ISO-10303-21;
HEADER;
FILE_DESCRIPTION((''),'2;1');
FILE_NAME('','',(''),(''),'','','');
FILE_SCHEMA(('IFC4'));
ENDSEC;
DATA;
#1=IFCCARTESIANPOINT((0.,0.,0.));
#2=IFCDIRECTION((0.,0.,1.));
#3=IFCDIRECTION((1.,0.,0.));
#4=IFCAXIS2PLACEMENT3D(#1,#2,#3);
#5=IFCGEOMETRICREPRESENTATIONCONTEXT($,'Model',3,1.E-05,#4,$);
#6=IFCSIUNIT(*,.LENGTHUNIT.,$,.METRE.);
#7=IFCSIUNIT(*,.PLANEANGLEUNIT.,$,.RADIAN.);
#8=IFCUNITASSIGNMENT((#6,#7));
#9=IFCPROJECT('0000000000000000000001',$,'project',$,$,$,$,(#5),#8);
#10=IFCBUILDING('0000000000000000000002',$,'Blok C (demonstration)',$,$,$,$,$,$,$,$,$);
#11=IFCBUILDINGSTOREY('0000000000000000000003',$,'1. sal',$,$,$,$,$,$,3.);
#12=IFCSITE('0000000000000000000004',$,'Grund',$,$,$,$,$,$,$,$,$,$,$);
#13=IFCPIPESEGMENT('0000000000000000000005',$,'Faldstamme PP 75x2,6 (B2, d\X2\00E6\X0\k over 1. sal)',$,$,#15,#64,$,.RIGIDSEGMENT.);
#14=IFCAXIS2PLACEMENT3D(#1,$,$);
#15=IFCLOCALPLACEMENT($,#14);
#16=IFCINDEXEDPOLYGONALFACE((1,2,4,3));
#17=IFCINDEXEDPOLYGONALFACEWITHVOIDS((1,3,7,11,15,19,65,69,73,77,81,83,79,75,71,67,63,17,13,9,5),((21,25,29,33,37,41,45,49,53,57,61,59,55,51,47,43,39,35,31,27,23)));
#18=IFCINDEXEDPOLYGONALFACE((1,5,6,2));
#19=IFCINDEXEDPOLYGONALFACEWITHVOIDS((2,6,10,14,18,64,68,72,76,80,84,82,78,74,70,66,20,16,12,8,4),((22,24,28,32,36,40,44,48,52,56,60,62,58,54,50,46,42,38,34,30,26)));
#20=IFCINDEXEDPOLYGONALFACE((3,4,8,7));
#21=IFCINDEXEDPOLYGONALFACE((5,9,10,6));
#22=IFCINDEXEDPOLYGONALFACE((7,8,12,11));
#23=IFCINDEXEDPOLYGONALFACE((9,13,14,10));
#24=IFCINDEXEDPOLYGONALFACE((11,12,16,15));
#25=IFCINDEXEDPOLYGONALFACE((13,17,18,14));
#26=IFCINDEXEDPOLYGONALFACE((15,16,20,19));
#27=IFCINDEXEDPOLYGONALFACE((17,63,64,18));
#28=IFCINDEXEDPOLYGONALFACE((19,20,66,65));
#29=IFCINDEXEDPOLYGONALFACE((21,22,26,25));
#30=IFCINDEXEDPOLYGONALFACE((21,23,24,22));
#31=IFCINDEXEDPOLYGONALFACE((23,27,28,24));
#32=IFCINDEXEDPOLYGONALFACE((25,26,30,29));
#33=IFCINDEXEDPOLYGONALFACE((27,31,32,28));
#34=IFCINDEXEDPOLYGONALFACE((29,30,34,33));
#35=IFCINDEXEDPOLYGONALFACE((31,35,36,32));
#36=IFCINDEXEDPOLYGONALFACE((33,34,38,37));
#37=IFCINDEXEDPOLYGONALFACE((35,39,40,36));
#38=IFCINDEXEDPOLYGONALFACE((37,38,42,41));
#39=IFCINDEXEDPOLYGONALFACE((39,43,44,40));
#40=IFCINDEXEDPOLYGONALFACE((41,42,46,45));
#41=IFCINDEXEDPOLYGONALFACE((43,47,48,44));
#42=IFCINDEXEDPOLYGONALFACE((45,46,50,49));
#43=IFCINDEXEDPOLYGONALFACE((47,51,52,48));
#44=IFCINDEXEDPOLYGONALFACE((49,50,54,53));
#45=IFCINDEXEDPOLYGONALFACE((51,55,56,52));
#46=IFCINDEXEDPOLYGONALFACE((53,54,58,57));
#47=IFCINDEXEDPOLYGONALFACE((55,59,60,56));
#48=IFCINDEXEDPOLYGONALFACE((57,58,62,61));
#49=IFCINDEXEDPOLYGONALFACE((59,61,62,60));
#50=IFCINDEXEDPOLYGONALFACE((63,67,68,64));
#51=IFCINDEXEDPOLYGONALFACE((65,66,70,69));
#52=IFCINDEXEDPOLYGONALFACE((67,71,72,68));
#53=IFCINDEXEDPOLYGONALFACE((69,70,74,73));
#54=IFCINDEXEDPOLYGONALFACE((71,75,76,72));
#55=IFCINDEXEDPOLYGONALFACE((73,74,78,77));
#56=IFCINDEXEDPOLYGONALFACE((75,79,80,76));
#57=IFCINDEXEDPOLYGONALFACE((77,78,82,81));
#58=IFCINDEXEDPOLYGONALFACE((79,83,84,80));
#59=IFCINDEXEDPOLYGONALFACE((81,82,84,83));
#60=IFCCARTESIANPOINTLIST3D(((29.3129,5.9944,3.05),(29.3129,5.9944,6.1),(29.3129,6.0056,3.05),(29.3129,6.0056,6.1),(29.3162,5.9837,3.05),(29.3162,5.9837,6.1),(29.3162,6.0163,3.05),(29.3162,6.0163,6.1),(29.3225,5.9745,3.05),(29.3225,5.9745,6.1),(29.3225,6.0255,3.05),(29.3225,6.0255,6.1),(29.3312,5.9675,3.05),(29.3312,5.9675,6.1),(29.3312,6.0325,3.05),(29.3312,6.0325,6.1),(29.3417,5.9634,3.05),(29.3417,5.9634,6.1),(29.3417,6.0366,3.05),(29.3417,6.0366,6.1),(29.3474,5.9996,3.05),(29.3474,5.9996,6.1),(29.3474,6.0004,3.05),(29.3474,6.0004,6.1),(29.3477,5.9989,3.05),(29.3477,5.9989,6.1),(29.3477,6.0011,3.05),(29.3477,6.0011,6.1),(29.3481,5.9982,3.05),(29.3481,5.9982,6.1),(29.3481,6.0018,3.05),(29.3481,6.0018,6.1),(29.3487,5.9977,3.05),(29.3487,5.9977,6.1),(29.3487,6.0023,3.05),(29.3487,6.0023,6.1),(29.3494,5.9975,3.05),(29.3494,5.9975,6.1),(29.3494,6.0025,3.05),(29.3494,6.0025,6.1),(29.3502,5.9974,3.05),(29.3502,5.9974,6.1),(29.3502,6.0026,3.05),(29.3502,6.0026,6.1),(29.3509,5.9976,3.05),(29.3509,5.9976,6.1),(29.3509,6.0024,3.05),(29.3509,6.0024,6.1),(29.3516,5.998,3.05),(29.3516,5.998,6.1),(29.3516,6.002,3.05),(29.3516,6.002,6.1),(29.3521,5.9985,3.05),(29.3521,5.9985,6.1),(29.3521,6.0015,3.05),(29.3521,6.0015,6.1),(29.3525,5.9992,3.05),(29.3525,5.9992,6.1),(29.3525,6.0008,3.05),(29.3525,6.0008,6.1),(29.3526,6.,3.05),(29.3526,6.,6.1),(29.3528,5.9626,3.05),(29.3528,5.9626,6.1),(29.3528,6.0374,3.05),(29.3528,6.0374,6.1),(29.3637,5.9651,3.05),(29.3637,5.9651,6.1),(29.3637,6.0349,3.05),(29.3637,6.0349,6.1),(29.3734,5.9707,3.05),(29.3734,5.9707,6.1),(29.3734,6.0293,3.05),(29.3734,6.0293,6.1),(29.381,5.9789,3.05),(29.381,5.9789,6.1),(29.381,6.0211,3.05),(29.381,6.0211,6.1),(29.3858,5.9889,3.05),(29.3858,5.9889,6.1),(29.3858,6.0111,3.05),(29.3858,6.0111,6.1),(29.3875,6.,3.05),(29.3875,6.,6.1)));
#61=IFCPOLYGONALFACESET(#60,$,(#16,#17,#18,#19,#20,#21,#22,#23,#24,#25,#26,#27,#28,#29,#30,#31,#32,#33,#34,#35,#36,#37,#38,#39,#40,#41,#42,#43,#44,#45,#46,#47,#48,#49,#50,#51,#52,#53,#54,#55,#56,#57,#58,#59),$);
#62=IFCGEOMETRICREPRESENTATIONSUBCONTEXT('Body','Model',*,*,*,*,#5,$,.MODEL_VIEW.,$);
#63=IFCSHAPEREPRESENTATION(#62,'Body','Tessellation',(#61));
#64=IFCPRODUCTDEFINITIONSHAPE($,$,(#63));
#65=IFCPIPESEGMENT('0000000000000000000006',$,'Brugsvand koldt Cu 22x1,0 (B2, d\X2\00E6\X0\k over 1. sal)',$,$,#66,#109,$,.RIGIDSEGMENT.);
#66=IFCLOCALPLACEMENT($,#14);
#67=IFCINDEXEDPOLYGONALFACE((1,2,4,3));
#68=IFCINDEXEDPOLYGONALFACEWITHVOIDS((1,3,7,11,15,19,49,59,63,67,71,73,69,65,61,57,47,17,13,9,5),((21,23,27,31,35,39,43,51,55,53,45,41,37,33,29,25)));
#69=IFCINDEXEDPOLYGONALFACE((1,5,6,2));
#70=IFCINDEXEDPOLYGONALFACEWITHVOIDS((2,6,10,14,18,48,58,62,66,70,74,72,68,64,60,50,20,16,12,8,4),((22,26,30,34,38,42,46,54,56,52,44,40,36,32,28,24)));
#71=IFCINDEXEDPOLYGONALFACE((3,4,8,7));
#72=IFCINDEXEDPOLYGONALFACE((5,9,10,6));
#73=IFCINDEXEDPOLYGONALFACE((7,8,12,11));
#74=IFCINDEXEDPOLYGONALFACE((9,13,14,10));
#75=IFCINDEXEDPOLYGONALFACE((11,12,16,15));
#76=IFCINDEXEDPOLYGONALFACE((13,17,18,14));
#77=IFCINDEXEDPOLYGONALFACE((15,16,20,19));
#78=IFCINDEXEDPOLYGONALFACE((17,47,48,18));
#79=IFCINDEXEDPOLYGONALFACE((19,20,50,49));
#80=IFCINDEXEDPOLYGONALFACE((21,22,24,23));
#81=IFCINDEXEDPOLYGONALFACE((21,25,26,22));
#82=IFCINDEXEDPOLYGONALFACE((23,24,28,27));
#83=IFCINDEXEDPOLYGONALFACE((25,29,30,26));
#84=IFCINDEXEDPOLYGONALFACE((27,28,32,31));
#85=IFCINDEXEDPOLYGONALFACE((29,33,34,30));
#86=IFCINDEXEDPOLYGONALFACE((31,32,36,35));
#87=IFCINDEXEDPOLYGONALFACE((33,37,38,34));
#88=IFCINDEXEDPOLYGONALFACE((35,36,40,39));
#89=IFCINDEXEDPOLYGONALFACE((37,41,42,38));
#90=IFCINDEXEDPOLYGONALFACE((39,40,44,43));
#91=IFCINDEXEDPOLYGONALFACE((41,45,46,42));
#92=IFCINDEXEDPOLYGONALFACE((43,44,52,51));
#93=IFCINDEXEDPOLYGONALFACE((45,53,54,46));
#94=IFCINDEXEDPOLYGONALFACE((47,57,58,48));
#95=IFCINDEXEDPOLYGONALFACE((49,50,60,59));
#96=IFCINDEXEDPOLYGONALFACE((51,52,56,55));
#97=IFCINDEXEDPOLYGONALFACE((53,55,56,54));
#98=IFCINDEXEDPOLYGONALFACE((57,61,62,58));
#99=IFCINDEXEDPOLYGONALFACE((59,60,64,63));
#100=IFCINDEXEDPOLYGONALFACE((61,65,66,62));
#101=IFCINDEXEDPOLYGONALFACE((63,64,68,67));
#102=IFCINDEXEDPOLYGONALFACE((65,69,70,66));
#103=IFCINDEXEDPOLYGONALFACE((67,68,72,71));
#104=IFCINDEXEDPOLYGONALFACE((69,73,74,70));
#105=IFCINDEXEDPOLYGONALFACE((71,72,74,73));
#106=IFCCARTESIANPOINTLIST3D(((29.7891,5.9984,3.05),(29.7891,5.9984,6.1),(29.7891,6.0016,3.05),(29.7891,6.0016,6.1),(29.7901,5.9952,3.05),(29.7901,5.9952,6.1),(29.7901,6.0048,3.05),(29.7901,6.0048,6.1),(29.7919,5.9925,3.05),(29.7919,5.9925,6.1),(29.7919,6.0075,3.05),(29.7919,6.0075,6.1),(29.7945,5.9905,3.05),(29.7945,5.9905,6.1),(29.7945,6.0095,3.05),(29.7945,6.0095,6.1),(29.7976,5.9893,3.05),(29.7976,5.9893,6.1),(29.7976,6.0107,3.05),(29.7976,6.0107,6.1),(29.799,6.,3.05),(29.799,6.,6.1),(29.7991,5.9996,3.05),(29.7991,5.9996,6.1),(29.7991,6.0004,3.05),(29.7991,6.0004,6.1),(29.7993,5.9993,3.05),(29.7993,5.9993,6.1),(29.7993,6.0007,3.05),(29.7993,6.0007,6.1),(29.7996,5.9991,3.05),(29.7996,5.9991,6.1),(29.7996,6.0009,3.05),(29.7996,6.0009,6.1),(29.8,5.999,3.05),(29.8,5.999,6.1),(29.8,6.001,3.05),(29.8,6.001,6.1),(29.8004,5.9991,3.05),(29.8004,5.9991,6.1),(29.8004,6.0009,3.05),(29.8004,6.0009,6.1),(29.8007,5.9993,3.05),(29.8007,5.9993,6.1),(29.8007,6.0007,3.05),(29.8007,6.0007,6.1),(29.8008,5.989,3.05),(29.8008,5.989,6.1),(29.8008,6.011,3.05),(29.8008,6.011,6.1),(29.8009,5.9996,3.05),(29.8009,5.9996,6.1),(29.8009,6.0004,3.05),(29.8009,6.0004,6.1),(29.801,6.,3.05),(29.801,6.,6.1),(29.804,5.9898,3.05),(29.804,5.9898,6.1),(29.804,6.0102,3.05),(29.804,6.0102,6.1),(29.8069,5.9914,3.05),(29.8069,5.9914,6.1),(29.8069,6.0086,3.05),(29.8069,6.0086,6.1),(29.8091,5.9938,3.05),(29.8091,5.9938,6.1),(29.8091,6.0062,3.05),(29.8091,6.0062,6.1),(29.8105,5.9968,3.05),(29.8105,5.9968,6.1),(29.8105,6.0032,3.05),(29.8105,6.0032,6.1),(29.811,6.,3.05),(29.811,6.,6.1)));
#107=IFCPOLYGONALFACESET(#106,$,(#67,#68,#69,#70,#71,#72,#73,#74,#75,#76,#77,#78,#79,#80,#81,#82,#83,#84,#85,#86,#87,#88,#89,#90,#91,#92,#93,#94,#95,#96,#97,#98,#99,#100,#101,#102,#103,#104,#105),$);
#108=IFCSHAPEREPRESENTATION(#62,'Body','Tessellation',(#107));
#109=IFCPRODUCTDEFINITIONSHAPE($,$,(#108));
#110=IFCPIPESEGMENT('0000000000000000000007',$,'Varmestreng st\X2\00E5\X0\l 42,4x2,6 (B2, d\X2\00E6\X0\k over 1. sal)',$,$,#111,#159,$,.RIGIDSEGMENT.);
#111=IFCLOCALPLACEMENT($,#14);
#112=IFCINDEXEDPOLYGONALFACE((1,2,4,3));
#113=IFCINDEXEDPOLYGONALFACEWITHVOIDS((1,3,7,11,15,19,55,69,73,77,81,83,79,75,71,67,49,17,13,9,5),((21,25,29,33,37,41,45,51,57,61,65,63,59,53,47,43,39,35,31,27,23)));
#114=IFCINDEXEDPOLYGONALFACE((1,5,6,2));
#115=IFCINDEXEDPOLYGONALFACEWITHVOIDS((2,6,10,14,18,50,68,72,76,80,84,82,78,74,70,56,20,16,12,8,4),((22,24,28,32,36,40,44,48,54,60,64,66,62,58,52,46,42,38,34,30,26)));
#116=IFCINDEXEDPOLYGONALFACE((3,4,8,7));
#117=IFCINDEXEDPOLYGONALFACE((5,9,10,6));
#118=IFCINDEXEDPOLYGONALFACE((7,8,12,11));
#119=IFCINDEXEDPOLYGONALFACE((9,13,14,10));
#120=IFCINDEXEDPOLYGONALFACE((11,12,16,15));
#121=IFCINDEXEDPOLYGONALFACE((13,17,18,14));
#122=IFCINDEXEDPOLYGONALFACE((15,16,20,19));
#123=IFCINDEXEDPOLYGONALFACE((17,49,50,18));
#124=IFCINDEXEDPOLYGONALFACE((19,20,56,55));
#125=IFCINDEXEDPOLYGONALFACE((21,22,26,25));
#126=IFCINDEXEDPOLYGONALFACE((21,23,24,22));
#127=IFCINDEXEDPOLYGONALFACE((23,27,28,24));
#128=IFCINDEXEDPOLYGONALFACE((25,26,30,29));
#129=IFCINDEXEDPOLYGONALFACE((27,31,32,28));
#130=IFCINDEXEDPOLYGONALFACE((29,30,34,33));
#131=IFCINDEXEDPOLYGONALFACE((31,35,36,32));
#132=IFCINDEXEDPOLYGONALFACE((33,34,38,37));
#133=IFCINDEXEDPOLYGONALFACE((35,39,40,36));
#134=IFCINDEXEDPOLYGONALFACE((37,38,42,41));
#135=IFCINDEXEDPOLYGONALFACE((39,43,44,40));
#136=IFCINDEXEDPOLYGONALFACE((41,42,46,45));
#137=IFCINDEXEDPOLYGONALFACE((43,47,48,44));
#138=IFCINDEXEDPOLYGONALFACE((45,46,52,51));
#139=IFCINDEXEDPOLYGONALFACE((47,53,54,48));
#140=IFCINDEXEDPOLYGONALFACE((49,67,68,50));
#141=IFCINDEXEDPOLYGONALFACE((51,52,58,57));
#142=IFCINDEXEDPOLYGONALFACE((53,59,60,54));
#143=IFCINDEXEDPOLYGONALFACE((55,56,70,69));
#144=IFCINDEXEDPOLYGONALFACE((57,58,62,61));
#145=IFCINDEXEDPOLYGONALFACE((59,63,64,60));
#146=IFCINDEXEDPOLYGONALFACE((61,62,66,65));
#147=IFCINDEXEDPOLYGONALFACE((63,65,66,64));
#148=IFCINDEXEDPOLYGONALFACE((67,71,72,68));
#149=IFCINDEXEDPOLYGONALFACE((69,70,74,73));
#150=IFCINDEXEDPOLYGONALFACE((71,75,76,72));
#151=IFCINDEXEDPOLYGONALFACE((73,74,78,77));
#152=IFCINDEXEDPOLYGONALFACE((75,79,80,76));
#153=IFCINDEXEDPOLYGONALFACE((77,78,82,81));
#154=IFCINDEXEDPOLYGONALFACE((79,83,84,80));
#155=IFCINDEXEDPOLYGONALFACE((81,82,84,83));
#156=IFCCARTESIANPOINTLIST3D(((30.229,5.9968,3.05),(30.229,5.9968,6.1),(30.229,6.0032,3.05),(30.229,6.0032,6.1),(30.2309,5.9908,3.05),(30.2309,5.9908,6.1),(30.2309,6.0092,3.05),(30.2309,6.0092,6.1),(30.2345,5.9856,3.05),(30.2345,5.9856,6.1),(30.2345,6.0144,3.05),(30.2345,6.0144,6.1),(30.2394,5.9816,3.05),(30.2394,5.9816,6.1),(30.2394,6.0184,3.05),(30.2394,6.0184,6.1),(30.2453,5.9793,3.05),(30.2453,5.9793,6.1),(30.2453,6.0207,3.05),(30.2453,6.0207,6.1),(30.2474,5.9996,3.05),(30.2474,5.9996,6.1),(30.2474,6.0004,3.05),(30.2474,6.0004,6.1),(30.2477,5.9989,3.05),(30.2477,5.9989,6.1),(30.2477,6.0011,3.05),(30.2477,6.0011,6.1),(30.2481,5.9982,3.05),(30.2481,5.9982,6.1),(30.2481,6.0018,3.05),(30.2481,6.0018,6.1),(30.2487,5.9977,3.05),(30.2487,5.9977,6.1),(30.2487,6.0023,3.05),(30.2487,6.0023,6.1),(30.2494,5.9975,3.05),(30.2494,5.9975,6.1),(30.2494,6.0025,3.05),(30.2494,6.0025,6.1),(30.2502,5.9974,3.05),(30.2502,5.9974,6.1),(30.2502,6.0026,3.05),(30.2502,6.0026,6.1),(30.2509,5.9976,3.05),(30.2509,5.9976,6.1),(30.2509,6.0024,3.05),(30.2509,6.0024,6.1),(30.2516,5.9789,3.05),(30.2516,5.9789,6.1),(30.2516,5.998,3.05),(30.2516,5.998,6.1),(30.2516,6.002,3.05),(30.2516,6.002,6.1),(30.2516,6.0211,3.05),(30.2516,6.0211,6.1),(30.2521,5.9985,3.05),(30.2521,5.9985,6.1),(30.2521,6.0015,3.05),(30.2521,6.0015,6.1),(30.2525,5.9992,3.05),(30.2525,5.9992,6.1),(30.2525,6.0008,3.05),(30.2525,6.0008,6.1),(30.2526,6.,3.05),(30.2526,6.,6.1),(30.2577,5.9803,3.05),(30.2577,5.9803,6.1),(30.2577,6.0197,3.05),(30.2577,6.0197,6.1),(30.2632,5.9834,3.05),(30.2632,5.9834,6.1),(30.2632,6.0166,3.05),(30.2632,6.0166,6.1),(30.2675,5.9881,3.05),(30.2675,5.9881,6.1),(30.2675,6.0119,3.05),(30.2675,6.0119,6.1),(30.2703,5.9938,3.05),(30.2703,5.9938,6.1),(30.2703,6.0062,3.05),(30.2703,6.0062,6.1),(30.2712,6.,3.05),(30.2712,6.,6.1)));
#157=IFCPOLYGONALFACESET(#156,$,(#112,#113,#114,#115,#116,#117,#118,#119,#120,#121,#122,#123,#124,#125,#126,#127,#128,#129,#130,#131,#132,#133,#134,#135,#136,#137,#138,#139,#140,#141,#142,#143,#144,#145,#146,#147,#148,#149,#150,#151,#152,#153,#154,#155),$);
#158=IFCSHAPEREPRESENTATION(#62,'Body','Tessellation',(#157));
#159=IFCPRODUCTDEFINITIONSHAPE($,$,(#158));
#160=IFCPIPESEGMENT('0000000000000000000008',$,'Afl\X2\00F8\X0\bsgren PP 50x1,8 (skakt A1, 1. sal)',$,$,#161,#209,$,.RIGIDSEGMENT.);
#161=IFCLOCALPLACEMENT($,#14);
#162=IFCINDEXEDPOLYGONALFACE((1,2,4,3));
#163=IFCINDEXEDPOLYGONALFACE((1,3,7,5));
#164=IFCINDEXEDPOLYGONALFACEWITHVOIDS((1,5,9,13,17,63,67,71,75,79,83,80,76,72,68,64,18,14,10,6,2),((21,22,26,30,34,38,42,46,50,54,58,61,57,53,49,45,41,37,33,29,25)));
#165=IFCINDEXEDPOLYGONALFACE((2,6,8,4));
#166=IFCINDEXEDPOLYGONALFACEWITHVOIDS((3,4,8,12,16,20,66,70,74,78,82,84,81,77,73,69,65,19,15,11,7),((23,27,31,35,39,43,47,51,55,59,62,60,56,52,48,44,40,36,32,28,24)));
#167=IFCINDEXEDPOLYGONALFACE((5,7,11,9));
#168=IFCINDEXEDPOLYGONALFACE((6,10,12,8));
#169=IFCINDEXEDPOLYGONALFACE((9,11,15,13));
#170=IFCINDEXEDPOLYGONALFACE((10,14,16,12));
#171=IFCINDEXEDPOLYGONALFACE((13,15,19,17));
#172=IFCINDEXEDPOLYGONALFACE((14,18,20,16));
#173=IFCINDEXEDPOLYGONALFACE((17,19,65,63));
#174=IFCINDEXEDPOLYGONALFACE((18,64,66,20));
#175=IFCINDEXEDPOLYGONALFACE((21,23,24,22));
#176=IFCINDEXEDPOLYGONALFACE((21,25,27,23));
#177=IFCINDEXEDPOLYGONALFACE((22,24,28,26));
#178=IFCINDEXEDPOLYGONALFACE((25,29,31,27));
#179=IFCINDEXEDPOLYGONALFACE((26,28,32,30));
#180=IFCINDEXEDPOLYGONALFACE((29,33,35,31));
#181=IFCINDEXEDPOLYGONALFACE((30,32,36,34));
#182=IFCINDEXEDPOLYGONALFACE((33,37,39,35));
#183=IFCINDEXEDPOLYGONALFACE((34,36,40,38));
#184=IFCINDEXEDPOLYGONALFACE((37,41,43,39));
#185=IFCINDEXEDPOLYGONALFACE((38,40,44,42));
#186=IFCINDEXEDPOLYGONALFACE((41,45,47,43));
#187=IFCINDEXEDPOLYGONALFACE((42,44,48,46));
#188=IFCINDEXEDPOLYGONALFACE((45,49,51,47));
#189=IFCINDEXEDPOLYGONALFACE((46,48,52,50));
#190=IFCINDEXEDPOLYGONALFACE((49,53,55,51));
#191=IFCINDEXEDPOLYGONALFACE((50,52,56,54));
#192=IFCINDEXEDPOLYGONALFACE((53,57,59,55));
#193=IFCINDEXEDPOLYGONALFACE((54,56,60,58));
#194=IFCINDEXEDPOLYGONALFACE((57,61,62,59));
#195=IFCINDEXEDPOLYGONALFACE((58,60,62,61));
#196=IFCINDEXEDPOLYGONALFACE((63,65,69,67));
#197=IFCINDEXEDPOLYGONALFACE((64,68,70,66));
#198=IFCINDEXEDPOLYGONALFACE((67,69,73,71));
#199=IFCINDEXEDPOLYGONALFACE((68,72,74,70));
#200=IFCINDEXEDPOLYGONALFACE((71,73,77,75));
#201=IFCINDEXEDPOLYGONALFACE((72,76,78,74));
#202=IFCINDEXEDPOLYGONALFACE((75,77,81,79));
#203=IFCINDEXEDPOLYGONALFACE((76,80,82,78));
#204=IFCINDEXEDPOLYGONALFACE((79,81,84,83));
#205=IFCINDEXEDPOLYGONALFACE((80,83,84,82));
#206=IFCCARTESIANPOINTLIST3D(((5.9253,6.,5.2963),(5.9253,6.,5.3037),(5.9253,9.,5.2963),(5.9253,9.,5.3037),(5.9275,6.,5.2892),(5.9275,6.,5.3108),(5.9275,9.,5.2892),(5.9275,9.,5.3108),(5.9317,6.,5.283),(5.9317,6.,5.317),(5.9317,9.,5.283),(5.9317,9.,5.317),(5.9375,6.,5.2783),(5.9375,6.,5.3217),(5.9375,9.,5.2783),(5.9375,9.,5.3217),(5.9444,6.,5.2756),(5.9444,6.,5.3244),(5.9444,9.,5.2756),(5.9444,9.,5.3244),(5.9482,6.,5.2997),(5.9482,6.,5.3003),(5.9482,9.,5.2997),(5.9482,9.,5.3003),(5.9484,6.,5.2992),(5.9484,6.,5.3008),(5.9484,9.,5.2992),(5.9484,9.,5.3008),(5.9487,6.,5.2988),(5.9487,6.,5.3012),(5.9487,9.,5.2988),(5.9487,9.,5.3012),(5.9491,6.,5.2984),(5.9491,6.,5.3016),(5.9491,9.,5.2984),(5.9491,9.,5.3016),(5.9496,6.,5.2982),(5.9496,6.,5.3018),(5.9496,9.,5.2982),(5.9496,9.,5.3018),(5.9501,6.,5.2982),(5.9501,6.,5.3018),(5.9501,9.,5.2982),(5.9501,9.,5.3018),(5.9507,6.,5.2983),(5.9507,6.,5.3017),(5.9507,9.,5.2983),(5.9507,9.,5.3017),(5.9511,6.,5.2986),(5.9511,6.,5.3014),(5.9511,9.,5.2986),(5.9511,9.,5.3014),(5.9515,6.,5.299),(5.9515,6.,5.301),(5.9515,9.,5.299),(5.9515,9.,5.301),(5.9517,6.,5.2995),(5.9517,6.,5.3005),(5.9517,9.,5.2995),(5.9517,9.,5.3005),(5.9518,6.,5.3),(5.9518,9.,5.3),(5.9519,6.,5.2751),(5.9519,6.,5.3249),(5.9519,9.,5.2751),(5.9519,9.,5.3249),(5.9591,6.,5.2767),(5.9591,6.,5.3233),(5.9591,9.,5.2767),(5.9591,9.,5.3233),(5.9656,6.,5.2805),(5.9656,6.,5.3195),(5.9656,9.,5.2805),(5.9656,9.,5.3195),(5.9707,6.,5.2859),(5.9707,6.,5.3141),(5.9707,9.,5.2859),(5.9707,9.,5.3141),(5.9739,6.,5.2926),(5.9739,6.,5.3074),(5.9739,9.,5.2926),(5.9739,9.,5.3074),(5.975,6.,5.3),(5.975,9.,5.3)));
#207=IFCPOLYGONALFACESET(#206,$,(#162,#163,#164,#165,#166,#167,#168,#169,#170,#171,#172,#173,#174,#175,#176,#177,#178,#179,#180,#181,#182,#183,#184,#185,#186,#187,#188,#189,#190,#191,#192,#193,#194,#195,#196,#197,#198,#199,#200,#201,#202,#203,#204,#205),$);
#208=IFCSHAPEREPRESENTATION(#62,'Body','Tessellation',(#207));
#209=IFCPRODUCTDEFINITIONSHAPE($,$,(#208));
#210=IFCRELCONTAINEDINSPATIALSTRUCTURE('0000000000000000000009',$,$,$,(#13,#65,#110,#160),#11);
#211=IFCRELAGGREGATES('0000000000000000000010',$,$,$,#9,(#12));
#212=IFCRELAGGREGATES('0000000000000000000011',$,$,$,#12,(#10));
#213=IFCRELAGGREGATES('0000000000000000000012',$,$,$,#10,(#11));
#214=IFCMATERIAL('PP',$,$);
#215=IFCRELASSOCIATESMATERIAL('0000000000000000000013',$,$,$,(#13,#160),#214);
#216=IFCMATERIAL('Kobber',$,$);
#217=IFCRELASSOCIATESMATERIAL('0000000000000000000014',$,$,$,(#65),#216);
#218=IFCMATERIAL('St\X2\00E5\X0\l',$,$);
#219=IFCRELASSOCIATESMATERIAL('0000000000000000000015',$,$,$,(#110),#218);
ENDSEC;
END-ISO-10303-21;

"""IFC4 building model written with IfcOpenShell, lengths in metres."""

from ifc_helpers import new_model, si_unit, frame, origin_with_axes, place, context, subcontext, project, spatial, hollow_circle, extrude, material, element, save


model = new_model("IFC4")

# Units and contexts
model_context = context("Model", 3, precision=1e-05, world=origin_with_axes())
body_context = subcontext(model_context, "Body", "Model", "MODEL_VIEW")
ifc_project = project(units=[si_unit("LENGTHUNIT", "METRE"), si_unit("PLANEANGLEUNIT", "RADIAN")], contexts=[model_context])

# Site, building, storey
site = spatial("IfcSite", under=ifc_project, Name="Grund")
building = spatial("IfcBuilding", under=site, Name="Blok C (demonstration)")
storey = spatial("IfcBuildingStorey", under=building, Name="1. sal", Elevation=3.0)

# Pipe segments
ifc_material_1 = material(Name="Kobber")
ifc_material_2 = material(Name="PP")
pipe_segment_1_placement = place(None, origin_with_axes())
element("IfcPipeSegment", 1, at=pipe_segment_1_placement, inside=storey, material=ifc_material_2, Name="Faldstamme PP 75x2,6 (B2, dæk over 1. sal)", PredefinedType="RIGIDSEGMENT", context=body_context, shape_type="SweptSolid", body=[
    extrude(hollow_circle(Radius=0.0375, WallThickness=0.0349), frame((29.35, 6.0, 3.05), z_axis=(0.0, 0.0, 1.0), x_axis=(1.0, 0.0, 0.0)), (0.0, 0.0, 1.0), 3.05),
])
pipe_segment_2_placement = place(None, origin_with_axes())
element("IfcPipeSegment", 2, at=pipe_segment_2_placement, inside=storey, material=ifc_material_1, Name="Brugsvand koldt Cu 22x1,0 (B2, dæk over 1. sal)", PredefinedType="RIGIDSEGMENT", context=body_context, shape_type="SweptSolid", body=[
    extrude(hollow_circle(Radius=0.011, WallThickness=0.01), frame((29.8, 6.0, 3.05), z_axis=(0.0, 0.0, 1.0), x_axis=(1.0, 0.0, 0.0)), (0.0, 0.0, 1.0), 3.05),
])
ifc_material_3 = material(Name="Stål")
pipe_segment_3_placement = place(None, origin_with_axes())
element("IfcPipeSegment", 3, at=pipe_segment_3_placement, inside=storey, material=ifc_material_3, Name="Varmestreng stål 42,4x2,6 (B2, dæk over 1. sal)", PredefinedType="RIGIDSEGMENT", context=body_context, shape_type="SweptSolid", body=[
    extrude(hollow_circle(Radius=0.0212, WallThickness=0.0186), frame((30.25, 6.0, 3.05), z_axis=(0.0, 0.0, 1.0), x_axis=(1.0, 0.0, 0.0)), (0.0, 0.0, 1.0), 3.05),
])
pipe_segment_4_placement = place(None, origin_with_axes())
element("IfcPipeSegment", 4, at=pipe_segment_4_placement, inside=storey, material=ifc_material_2, Name="Afløbsgren PP 50x1,8 (skakt A1, 1. sal)", PredefinedType="RIGIDSEGMENT", context=body_context, shape_type="SweptSolid", body=[
    extrude(hollow_circle(Radius=0.025, WallThickness=0.0232), frame((5.95, 6.0, 5.3), z_axis=(0.0, 1.0, 0.0), x_axis=(1.0, 0.0, 0.0)), (0.0, 0.0, 1.0), 3.0),
])

save(model, "model.ifc")
